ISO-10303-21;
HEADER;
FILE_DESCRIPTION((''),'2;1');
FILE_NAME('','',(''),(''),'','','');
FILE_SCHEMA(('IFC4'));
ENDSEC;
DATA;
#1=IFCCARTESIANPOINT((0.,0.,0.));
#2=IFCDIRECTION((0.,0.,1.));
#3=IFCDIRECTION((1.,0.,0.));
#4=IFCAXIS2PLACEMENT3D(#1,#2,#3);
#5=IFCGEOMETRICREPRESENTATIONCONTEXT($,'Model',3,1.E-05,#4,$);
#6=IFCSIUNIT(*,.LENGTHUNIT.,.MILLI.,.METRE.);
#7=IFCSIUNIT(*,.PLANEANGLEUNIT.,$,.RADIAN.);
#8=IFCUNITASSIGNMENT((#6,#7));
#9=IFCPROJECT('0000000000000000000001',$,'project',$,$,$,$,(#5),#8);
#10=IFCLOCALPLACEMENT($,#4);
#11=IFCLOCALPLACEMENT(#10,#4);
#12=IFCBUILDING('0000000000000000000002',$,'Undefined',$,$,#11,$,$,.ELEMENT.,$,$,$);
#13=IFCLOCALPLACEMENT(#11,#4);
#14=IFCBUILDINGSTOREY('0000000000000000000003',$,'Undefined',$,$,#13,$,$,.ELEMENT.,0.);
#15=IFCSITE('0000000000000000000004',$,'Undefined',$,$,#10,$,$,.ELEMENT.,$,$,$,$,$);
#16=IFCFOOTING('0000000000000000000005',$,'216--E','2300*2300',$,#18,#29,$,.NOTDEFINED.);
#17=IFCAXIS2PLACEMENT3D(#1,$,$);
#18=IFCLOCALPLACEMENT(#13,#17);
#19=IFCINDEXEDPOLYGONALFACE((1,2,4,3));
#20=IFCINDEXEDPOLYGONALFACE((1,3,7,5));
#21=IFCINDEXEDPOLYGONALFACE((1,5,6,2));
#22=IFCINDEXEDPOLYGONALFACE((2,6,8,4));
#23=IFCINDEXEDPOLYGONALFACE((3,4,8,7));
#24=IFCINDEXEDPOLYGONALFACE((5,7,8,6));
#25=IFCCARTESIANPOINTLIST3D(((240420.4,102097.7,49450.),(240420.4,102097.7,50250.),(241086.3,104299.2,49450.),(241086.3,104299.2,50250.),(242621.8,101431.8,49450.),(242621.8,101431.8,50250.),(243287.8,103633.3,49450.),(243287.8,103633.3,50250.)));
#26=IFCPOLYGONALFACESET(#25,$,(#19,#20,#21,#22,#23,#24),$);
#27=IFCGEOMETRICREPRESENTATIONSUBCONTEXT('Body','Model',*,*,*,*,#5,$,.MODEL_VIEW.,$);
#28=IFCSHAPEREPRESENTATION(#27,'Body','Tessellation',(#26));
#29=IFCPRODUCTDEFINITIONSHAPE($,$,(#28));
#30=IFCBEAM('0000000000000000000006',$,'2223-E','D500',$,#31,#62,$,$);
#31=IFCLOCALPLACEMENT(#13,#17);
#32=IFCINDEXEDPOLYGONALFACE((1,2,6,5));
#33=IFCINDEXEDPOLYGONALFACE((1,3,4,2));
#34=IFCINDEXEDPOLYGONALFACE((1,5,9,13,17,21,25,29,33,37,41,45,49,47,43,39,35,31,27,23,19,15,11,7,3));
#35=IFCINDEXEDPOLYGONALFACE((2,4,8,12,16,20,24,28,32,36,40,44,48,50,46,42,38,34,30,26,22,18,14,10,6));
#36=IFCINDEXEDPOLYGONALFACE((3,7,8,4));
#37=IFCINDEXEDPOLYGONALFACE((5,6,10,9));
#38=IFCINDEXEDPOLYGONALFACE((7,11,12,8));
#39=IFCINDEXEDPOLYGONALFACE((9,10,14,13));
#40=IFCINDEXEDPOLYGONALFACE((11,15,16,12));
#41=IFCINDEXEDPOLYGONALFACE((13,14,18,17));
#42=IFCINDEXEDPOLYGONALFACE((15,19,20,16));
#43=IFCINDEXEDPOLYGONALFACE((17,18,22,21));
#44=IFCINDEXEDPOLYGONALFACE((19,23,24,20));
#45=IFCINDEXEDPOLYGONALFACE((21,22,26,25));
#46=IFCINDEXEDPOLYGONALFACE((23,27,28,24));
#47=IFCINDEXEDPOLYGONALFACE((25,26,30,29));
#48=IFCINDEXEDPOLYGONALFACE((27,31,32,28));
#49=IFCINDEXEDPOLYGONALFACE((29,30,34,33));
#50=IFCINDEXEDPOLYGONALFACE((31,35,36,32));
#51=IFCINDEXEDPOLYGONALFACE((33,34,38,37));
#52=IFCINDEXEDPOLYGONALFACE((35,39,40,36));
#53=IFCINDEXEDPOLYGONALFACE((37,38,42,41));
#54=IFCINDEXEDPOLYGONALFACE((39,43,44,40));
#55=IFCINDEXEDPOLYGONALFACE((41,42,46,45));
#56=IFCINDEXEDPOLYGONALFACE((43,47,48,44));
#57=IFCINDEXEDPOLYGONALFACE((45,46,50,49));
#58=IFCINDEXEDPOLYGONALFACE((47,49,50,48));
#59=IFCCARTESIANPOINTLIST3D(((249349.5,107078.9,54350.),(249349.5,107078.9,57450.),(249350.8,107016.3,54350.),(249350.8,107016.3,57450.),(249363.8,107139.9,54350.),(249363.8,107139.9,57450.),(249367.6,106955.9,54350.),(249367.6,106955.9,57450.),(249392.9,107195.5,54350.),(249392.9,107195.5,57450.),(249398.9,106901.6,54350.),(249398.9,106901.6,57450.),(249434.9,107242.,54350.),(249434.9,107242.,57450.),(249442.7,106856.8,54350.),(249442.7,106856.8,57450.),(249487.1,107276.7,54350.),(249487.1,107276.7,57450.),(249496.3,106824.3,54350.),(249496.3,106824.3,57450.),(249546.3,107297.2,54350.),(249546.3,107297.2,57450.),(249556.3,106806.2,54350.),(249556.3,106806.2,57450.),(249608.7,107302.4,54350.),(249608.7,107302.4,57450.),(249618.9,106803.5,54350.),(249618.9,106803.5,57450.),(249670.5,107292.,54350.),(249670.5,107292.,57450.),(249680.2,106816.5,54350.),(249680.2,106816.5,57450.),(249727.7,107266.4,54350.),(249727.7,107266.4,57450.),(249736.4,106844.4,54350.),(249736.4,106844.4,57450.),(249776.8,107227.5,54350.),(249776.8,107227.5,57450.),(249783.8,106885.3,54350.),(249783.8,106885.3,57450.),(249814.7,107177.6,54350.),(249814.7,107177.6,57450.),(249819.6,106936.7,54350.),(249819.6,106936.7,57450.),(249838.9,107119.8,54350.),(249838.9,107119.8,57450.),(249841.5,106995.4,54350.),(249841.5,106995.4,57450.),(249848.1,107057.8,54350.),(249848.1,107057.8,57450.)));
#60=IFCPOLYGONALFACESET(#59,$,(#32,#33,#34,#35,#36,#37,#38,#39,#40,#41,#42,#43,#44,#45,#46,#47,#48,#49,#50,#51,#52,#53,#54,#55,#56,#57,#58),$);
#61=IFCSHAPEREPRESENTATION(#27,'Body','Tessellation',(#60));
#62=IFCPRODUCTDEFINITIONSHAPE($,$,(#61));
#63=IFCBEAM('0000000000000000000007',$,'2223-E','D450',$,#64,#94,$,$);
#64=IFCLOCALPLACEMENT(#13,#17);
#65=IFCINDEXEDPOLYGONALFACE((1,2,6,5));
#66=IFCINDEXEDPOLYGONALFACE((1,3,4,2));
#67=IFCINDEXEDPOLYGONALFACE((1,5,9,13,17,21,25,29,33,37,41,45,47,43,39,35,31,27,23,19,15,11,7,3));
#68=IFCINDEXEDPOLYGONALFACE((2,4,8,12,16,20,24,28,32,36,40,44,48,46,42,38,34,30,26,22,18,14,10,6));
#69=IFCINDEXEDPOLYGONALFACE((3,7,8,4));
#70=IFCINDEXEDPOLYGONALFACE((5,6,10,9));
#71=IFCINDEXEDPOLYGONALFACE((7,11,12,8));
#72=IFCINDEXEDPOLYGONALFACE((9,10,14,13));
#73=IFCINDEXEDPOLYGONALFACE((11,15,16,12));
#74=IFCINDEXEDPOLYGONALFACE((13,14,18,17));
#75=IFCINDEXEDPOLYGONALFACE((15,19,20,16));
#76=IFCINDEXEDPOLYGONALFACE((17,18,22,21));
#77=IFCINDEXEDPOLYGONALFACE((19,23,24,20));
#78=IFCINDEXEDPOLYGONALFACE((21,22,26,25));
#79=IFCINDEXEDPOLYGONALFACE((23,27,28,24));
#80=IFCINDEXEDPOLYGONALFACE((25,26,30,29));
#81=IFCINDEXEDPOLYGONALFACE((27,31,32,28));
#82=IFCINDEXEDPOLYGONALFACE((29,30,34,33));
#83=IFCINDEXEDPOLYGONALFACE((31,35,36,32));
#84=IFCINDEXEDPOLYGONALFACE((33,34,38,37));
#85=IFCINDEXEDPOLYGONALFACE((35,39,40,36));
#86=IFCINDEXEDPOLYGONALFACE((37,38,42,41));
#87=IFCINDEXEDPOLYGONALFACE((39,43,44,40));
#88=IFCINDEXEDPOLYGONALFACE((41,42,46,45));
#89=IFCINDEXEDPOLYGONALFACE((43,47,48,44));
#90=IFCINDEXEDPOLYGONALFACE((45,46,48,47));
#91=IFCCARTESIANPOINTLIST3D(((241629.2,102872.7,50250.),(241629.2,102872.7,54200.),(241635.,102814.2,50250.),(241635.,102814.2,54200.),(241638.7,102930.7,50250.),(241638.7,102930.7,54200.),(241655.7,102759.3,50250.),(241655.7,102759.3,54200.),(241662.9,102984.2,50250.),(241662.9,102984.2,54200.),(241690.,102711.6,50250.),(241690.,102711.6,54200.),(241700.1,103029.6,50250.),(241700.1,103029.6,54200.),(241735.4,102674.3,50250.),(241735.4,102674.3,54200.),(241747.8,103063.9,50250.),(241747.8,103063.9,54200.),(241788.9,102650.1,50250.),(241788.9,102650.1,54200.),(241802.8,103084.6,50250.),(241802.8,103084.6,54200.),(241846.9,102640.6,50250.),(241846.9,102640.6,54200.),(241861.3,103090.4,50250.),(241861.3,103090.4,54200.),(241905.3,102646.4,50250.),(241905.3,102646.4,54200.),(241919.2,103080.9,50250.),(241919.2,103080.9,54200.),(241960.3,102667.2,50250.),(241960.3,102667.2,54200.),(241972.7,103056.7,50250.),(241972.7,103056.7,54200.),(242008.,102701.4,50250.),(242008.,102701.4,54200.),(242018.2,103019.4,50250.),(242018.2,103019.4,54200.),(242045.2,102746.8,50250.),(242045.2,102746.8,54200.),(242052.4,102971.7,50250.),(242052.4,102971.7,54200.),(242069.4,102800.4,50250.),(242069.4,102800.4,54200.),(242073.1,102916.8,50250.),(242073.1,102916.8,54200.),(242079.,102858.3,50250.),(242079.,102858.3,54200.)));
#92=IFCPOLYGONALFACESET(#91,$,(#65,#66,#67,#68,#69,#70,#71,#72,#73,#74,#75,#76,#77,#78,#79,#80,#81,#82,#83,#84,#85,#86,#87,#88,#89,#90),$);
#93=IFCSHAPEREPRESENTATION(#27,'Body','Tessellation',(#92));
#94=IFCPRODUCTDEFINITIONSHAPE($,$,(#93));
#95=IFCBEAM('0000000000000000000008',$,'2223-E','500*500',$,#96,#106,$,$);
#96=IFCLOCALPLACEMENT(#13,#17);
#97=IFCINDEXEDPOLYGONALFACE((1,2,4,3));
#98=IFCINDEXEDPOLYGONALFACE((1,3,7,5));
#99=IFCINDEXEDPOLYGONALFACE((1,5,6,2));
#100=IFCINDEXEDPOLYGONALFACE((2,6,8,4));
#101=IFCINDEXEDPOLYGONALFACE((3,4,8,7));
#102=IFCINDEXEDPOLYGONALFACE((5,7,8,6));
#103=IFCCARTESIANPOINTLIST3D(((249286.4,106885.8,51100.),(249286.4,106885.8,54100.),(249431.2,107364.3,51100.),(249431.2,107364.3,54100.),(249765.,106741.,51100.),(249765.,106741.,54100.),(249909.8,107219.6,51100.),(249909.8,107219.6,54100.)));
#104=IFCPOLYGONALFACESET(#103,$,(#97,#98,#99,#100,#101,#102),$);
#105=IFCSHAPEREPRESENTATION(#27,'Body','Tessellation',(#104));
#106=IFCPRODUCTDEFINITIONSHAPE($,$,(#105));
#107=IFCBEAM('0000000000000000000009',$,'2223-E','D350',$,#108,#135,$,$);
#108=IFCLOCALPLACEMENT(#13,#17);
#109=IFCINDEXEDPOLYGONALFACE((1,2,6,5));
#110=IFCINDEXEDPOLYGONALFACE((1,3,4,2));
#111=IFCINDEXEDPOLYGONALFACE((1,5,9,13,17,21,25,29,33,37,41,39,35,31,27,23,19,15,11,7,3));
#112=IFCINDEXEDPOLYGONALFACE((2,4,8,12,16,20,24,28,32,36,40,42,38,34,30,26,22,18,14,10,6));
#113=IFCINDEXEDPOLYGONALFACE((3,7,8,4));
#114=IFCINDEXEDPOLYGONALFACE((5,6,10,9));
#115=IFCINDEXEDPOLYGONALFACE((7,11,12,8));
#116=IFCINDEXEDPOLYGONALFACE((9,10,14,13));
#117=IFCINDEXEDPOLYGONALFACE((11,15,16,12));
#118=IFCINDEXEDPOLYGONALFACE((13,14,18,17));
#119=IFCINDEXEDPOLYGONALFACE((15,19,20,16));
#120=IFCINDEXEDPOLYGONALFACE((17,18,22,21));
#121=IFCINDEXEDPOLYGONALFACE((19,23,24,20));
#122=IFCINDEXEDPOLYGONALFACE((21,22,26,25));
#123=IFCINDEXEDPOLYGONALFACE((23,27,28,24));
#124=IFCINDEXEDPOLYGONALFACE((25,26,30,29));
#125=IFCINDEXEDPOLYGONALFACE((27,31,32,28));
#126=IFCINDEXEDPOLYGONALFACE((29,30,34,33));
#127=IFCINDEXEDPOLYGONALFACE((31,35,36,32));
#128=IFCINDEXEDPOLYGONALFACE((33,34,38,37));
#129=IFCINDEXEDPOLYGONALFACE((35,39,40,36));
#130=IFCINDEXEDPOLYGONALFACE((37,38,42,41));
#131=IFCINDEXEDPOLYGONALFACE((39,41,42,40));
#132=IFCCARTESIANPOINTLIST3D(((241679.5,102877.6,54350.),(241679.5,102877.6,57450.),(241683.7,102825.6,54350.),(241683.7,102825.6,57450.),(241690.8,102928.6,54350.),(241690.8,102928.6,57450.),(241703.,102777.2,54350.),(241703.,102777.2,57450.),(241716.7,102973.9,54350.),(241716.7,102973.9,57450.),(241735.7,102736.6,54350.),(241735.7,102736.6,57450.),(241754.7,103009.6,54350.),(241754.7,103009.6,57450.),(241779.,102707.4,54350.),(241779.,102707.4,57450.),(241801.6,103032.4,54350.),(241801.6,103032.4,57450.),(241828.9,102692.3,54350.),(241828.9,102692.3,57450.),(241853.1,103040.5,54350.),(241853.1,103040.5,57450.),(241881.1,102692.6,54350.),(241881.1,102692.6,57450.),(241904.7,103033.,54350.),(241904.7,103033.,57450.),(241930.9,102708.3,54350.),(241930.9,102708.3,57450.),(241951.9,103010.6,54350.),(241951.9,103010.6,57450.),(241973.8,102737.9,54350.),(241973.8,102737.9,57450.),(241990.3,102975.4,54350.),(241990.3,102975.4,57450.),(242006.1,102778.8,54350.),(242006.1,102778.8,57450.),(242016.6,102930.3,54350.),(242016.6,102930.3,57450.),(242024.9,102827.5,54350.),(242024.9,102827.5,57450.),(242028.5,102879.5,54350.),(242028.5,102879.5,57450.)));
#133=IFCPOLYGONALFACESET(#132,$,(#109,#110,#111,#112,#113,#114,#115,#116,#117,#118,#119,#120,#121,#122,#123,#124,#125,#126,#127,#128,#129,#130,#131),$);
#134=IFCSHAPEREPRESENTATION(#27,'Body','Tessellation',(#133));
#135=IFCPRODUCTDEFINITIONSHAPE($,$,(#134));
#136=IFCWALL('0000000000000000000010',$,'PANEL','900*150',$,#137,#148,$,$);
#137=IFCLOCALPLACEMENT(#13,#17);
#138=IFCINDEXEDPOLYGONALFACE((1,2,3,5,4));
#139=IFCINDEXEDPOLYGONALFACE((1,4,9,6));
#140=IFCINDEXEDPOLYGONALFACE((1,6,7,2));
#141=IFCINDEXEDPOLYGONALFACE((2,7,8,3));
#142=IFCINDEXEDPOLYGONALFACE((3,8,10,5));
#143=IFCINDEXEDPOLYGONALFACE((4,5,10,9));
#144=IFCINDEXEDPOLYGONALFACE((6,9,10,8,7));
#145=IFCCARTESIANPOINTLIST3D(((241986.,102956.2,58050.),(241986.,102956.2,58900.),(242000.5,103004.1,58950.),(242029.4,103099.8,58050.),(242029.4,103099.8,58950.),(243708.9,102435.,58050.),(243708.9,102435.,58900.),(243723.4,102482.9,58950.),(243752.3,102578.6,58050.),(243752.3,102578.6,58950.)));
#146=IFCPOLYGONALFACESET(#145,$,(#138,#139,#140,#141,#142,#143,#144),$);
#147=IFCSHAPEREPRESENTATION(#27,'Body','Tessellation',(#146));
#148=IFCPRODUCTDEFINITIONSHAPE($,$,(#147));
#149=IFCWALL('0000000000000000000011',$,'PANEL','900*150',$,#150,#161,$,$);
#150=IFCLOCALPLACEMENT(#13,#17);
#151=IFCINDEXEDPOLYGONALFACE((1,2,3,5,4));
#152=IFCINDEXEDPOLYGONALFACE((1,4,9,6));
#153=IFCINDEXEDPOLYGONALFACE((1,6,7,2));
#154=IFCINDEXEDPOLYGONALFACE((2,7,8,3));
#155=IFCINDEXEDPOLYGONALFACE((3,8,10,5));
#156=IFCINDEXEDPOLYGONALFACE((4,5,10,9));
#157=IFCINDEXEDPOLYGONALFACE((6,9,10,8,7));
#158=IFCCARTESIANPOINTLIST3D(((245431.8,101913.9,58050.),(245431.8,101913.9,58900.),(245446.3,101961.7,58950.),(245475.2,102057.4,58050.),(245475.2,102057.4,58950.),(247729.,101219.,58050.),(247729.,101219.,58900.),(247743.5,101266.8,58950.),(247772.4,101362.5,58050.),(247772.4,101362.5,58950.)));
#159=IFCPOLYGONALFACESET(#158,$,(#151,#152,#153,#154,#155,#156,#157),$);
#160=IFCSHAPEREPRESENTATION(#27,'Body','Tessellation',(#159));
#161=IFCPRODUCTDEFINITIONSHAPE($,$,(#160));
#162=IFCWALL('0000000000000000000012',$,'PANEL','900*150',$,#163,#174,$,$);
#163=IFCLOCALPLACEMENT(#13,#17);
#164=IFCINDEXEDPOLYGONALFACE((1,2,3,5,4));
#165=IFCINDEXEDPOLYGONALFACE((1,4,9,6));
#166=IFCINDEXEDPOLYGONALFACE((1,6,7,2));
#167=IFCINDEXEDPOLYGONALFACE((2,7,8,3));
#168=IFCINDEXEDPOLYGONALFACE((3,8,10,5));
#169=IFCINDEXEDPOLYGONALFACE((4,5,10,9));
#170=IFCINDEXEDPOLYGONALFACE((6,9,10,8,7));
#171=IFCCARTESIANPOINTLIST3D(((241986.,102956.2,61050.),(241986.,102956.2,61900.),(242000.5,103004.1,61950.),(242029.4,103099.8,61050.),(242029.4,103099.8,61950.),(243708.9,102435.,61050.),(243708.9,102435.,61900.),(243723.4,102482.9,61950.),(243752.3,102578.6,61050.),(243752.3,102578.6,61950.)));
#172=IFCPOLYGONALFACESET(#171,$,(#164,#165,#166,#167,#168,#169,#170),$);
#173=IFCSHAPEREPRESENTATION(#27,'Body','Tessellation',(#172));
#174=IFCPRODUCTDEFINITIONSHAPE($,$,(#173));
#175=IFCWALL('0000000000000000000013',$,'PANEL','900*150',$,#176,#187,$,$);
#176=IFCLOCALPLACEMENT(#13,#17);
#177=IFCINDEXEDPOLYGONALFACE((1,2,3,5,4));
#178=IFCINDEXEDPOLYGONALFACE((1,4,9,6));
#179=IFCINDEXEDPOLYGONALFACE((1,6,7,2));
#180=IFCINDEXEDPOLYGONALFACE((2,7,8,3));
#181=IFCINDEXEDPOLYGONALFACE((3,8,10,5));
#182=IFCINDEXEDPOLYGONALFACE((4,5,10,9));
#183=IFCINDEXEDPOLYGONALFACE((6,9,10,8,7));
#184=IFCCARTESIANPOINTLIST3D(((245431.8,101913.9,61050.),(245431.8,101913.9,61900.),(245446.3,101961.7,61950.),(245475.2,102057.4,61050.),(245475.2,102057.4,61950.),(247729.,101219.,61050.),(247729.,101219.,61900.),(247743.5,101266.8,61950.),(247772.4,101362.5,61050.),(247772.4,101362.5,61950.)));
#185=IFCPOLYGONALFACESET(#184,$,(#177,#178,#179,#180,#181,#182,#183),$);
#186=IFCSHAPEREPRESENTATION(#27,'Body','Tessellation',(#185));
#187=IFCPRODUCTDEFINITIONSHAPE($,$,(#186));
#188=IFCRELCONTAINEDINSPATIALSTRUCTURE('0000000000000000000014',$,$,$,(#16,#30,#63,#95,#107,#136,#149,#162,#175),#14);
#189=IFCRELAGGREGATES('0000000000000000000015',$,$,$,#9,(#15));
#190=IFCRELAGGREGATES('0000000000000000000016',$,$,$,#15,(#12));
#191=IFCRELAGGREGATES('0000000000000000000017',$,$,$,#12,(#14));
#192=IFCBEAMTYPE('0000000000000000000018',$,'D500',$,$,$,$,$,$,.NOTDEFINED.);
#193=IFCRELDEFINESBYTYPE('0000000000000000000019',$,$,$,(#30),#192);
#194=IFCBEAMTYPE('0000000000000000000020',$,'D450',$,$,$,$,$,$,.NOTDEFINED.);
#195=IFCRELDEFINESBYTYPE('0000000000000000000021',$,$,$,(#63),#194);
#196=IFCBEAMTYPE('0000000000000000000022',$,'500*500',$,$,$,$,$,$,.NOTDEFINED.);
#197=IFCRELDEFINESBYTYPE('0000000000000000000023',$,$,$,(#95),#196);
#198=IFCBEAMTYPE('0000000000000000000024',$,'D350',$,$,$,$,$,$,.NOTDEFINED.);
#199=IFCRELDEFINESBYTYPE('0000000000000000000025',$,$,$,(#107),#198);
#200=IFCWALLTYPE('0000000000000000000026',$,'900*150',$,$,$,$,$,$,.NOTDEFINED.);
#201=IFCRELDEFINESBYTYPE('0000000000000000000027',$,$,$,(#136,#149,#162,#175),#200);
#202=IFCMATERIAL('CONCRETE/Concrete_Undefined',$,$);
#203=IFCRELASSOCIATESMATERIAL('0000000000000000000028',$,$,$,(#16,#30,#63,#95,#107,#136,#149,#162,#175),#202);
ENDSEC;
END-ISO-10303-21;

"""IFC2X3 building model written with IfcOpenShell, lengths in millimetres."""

from ifc_helpers import new_model, si_unit, frame, frame_2d, origin_with_axes, origin_2d_with_axis, place, context, subcontext, project, spatial, rectangle, circle, extrude, clip, halfspace, material, type_object, element, save


model = new_model("IFC2X3")

# Units and contexts
model_context = context("Model", 3, precision=1e-05, world=origin_with_axes())
body_context = subcontext(model_context, "Body", "Model", "MODEL_VIEW")
ifc_project = project(units=[si_unit("LENGTHUNIT", "METRE", prefix="MILLI"), si_unit("PLANEANGLEUNIT", "RADIAN")], contexts=[model_context])

# Site, building, storey
site_placement = place(None, origin_with_axes())
site = spatial("IfcSite", under=ifc_project, at=site_placement, Name="Undefined", CompositionType="ELEMENT")
building_placement = place(site_placement, origin_with_axes())
building = spatial("IfcBuilding", under=site, at=building_placement, Name="Undefined", CompositionType="ELEMENT")
storey_placement = place(building_placement, origin_with_axes())
storey = spatial("IfcBuildingStorey", under=building, at=storey_placement, Name="Undefined", CompositionType="ELEMENT", Elevation=0.0)

# Footing
ifc_material_1 = material(Name="CONCRETE/Concrete_Undefined")
footing_placement = place(storey_placement, frame((241854.1, 102865.5, 49450.0), z_axis=(0.289538, 0.957166, 0.0), x_axis=(0.0, 0.0, 1.0)))
element("IfcFooting", 1, at=footing_placement, inside=storey, material=ifc_material_1, Name="216--E", Description="2300*2300", PredefinedType="NOTDEFINED", context=body_context, shape_type="SweptSolid", body=[
    extrude(rectangle(XDim=2300.0, YDim=2300.0, at=origin_2d_with_axis()), frame((800.0, 0.0, 0.0), z_axis=(-1.0, 0.0, 0.0), x_axis=(0.0, -1.0, 0.0)), (0.0, 0.0, 1.0), 800.0),
])

# Beams
beam_type_1 = type_object("IfcBeamType", Name="D500", PredefinedType="NOTDEFINED")
beam_1_placement = place(storey_placement, frame((249598.1, 107052.7, 54350.0), z_axis=(0.957167, -0.289538, 0.0), x_axis=(0.0, 0.0, 1.0)))
element("IfcBeam", 2, at=beam_1_placement, inside=storey, type_object=beam_type_1, material=ifc_material_1, Name="2223-E", Description="D500", context=body_context, shape_type="SweptSolid", body=[
    extrude(circle(Radius=250.0, at=origin_2d_with_axis()), frame((3100.0, 0.0, 0.0), z_axis=(-1.0, 0.0, 0.0), x_axis=(0.0, -1.0, 0.0)), (0.0, 0.0, 1.0), 3100.0),
])
beam_type_2 = type_object("IfcBeamType", Name="D450", PredefinedType="NOTDEFINED")
beam_2_placement = place(storey_placement, frame((241854.1, 102865.5, 50250.0), z_axis=(0.957167, -0.289538, 0.0), x_axis=(0.0, 0.0, 1.0)))
element("IfcBeam", 3, at=beam_2_placement, inside=storey, type_object=beam_type_2, material=ifc_material_1, Name="2223-E", Description="D450", context=body_context, shape_type="SweptSolid", body=[
    extrude(circle(Radius=225.0, at=origin_2d_with_axis()), frame((3950.0, 0.0, 0.0), z_axis=(-1.0, 0.0, 0.0), x_axis=(0.0, -1.0, 0.0)), (0.0, 0.0, 1.0), 3950.0),
])
beam_type_3 = type_object("IfcBeamType", Name="500*500", PredefinedType="NOTDEFINED")
beam_3_placement = place(storey_placement, frame((249598.1, 107052.7, 51100.0), z_axis=(0.957167, -0.289538, 0.0), x_axis=(0.0, 0.0, 1.0)))
element("IfcBeam", 4, at=beam_3_placement, inside=storey, type_object=beam_type_3, material=ifc_material_1, Name="2223-E", Description="500*500", context=body_context, shape_type="SweptSolid", body=[
    extrude(rectangle(XDim=500.0, YDim=500.0, at=origin_2d_with_axis()), frame((3000.0, 0.0, 0.0), z_axis=(-1.0, 0.0, 0.0), x_axis=(0.0, -1.0, 0.0)), (0.0, 0.0, 1.0), 3000.0),
])
beam_type_4 = type_object("IfcBeamType", Name="D350", PredefinedType="NOTDEFINED")
beam_4_placement = place(storey_placement, frame((241854.1, 102865.5, 54350.0), z_axis=(0.957167, -0.289538, 0.0), x_axis=(0.0, 0.0, 1.0)))
element("IfcBeam", 5, at=beam_4_placement, inside=storey, type_object=beam_type_4, material=ifc_material_1, Name="2223-E", Description="D350", context=body_context, shape_type="SweptSolid", body=[
    extrude(circle(Radius=175.0, at=origin_2d_with_axis()), frame((3100.0, 0.0, 0.0), z_axis=(-1.0, 0.0, 0.0), x_axis=(0.0, -1.0, 0.0)), (0.0, 0.0, 1.0), 3100.0),
])

# Walls
wall_type_1 = type_object("IfcWallType", Name="900*150", PredefinedType="NOTDEFINED")
wall_1_placement = place(storey_placement, frame((242007.7, 103028.0, 58050.0), z_axis=(0.0, 0.0, 1.0), x_axis=(0.957166, -0.289541, 0.0)))
element("IfcWall", 6, at=wall_1_placement, inside=storey, type_object=wall_type_1, material=ifc_material_1, Name="PANEL", Description="900*150", context=body_context, shape_type="Clipping", body=[
    clip(extrude(rectangle(XDim=1800.0, YDim=150.0, at=frame_2d((0.0, 900.0), x_axis=(0.0, -1.0))), frame((0.0, 0.0, 0.0), z_axis=(0.0, 0.0, 1.0), x_axis=(0.0, -1.0, 0.0)), (0.0, 0.0, 1.0), 900.0), halfspace(frame((2400.0, 75.0, 1000.0), z_axis=(0.000001, -0.707072, 0.707141), x_axis=(0.0, -0.707141, -0.707072)), False)),
])
wall_2_placement = place(storey_placement, frame((245453.5, 101985.7, 58050.0), z_axis=(0.0, 0.0, 1.0), x_axis=(0.957166, -0.289539, 0.0)))
element("IfcWall", 7, at=wall_2_placement, inside=storey, type_object=wall_type_1, material=ifc_material_1, Name="PANEL", Description="900*150", context=body_context, shape_type="Clipping", body=[
    clip(extrude(rectangle(XDim=2400.0, YDim=150.0, at=frame_2d((0.0, 1200.0), x_axis=(0.0, -1.0))), frame((0.0, 0.0, 0.0), z_axis=(0.0, 0.0, 1.0), x_axis=(0.0, -1.0, 0.0)), (0.0, 0.0, 1.0), 900.0), halfspace(frame((2400.0, 75.0, 1000.0), z_axis=(0.000001, -0.707072, 0.707141), x_axis=(0.0, -0.707141, -0.707072)), False)),
])
wall_3_placement = place(storey_placement, frame((242007.7, 103028.0, 61050.0), z_axis=(0.0, 0.0, 1.0), x_axis=(0.957166, -0.289541, 0.0)))
element("IfcWall", 8, at=wall_3_placement, inside=storey, type_object=wall_type_1, material=ifc_material_1, Name="PANEL", Description="900*150", context=body_context, shape_type="Clipping", body=[
    clip(extrude(rectangle(XDim=1800.0, YDim=150.0, at=frame_2d((0.0, 900.0), x_axis=(0.0, -1.0))), frame((0.0, 0.0, 0.0), z_axis=(0.0, 0.0, 1.0), x_axis=(0.0, -1.0, 0.0)), (0.0, 0.0, 1.0), 900.0), halfspace(frame((2400.0, 75.0, 1000.0), z_axis=(0.000001, -0.707072, 0.707141), x_axis=(0.0, -0.707141, -0.707072)), False)),
])
wall_4_placement = place(storey_placement, frame((245453.5, 101985.7, 61050.0), z_axis=(0.0, 0.0, 1.0), x_axis=(0.957166, -0.289539, 0.0)))
element("IfcWall", 9, at=wall_4_placement, inside=storey, type_object=wall_type_1, material=ifc_material_1, Name="PANEL", Description="900*150", context=body_context, shape_type="Clipping", body=[
    clip(extrude(rectangle(XDim=2400.0, YDim=150.0, at=frame_2d((0.0, 1200.0), x_axis=(0.0, -1.0))), frame((0.0, 0.0, 0.0), z_axis=(0.0, 0.0, 1.0), x_axis=(0.0, -1.0, 0.0)), (0.0, 0.0, 1.0), 900.0), halfspace(frame((2400.0, 75.0, 1000.0), z_axis=(0.000001, -0.707072, 0.707141), x_axis=(0.0, -0.707141, -0.707072)), False)),
])

save(model, "model.ifc")
